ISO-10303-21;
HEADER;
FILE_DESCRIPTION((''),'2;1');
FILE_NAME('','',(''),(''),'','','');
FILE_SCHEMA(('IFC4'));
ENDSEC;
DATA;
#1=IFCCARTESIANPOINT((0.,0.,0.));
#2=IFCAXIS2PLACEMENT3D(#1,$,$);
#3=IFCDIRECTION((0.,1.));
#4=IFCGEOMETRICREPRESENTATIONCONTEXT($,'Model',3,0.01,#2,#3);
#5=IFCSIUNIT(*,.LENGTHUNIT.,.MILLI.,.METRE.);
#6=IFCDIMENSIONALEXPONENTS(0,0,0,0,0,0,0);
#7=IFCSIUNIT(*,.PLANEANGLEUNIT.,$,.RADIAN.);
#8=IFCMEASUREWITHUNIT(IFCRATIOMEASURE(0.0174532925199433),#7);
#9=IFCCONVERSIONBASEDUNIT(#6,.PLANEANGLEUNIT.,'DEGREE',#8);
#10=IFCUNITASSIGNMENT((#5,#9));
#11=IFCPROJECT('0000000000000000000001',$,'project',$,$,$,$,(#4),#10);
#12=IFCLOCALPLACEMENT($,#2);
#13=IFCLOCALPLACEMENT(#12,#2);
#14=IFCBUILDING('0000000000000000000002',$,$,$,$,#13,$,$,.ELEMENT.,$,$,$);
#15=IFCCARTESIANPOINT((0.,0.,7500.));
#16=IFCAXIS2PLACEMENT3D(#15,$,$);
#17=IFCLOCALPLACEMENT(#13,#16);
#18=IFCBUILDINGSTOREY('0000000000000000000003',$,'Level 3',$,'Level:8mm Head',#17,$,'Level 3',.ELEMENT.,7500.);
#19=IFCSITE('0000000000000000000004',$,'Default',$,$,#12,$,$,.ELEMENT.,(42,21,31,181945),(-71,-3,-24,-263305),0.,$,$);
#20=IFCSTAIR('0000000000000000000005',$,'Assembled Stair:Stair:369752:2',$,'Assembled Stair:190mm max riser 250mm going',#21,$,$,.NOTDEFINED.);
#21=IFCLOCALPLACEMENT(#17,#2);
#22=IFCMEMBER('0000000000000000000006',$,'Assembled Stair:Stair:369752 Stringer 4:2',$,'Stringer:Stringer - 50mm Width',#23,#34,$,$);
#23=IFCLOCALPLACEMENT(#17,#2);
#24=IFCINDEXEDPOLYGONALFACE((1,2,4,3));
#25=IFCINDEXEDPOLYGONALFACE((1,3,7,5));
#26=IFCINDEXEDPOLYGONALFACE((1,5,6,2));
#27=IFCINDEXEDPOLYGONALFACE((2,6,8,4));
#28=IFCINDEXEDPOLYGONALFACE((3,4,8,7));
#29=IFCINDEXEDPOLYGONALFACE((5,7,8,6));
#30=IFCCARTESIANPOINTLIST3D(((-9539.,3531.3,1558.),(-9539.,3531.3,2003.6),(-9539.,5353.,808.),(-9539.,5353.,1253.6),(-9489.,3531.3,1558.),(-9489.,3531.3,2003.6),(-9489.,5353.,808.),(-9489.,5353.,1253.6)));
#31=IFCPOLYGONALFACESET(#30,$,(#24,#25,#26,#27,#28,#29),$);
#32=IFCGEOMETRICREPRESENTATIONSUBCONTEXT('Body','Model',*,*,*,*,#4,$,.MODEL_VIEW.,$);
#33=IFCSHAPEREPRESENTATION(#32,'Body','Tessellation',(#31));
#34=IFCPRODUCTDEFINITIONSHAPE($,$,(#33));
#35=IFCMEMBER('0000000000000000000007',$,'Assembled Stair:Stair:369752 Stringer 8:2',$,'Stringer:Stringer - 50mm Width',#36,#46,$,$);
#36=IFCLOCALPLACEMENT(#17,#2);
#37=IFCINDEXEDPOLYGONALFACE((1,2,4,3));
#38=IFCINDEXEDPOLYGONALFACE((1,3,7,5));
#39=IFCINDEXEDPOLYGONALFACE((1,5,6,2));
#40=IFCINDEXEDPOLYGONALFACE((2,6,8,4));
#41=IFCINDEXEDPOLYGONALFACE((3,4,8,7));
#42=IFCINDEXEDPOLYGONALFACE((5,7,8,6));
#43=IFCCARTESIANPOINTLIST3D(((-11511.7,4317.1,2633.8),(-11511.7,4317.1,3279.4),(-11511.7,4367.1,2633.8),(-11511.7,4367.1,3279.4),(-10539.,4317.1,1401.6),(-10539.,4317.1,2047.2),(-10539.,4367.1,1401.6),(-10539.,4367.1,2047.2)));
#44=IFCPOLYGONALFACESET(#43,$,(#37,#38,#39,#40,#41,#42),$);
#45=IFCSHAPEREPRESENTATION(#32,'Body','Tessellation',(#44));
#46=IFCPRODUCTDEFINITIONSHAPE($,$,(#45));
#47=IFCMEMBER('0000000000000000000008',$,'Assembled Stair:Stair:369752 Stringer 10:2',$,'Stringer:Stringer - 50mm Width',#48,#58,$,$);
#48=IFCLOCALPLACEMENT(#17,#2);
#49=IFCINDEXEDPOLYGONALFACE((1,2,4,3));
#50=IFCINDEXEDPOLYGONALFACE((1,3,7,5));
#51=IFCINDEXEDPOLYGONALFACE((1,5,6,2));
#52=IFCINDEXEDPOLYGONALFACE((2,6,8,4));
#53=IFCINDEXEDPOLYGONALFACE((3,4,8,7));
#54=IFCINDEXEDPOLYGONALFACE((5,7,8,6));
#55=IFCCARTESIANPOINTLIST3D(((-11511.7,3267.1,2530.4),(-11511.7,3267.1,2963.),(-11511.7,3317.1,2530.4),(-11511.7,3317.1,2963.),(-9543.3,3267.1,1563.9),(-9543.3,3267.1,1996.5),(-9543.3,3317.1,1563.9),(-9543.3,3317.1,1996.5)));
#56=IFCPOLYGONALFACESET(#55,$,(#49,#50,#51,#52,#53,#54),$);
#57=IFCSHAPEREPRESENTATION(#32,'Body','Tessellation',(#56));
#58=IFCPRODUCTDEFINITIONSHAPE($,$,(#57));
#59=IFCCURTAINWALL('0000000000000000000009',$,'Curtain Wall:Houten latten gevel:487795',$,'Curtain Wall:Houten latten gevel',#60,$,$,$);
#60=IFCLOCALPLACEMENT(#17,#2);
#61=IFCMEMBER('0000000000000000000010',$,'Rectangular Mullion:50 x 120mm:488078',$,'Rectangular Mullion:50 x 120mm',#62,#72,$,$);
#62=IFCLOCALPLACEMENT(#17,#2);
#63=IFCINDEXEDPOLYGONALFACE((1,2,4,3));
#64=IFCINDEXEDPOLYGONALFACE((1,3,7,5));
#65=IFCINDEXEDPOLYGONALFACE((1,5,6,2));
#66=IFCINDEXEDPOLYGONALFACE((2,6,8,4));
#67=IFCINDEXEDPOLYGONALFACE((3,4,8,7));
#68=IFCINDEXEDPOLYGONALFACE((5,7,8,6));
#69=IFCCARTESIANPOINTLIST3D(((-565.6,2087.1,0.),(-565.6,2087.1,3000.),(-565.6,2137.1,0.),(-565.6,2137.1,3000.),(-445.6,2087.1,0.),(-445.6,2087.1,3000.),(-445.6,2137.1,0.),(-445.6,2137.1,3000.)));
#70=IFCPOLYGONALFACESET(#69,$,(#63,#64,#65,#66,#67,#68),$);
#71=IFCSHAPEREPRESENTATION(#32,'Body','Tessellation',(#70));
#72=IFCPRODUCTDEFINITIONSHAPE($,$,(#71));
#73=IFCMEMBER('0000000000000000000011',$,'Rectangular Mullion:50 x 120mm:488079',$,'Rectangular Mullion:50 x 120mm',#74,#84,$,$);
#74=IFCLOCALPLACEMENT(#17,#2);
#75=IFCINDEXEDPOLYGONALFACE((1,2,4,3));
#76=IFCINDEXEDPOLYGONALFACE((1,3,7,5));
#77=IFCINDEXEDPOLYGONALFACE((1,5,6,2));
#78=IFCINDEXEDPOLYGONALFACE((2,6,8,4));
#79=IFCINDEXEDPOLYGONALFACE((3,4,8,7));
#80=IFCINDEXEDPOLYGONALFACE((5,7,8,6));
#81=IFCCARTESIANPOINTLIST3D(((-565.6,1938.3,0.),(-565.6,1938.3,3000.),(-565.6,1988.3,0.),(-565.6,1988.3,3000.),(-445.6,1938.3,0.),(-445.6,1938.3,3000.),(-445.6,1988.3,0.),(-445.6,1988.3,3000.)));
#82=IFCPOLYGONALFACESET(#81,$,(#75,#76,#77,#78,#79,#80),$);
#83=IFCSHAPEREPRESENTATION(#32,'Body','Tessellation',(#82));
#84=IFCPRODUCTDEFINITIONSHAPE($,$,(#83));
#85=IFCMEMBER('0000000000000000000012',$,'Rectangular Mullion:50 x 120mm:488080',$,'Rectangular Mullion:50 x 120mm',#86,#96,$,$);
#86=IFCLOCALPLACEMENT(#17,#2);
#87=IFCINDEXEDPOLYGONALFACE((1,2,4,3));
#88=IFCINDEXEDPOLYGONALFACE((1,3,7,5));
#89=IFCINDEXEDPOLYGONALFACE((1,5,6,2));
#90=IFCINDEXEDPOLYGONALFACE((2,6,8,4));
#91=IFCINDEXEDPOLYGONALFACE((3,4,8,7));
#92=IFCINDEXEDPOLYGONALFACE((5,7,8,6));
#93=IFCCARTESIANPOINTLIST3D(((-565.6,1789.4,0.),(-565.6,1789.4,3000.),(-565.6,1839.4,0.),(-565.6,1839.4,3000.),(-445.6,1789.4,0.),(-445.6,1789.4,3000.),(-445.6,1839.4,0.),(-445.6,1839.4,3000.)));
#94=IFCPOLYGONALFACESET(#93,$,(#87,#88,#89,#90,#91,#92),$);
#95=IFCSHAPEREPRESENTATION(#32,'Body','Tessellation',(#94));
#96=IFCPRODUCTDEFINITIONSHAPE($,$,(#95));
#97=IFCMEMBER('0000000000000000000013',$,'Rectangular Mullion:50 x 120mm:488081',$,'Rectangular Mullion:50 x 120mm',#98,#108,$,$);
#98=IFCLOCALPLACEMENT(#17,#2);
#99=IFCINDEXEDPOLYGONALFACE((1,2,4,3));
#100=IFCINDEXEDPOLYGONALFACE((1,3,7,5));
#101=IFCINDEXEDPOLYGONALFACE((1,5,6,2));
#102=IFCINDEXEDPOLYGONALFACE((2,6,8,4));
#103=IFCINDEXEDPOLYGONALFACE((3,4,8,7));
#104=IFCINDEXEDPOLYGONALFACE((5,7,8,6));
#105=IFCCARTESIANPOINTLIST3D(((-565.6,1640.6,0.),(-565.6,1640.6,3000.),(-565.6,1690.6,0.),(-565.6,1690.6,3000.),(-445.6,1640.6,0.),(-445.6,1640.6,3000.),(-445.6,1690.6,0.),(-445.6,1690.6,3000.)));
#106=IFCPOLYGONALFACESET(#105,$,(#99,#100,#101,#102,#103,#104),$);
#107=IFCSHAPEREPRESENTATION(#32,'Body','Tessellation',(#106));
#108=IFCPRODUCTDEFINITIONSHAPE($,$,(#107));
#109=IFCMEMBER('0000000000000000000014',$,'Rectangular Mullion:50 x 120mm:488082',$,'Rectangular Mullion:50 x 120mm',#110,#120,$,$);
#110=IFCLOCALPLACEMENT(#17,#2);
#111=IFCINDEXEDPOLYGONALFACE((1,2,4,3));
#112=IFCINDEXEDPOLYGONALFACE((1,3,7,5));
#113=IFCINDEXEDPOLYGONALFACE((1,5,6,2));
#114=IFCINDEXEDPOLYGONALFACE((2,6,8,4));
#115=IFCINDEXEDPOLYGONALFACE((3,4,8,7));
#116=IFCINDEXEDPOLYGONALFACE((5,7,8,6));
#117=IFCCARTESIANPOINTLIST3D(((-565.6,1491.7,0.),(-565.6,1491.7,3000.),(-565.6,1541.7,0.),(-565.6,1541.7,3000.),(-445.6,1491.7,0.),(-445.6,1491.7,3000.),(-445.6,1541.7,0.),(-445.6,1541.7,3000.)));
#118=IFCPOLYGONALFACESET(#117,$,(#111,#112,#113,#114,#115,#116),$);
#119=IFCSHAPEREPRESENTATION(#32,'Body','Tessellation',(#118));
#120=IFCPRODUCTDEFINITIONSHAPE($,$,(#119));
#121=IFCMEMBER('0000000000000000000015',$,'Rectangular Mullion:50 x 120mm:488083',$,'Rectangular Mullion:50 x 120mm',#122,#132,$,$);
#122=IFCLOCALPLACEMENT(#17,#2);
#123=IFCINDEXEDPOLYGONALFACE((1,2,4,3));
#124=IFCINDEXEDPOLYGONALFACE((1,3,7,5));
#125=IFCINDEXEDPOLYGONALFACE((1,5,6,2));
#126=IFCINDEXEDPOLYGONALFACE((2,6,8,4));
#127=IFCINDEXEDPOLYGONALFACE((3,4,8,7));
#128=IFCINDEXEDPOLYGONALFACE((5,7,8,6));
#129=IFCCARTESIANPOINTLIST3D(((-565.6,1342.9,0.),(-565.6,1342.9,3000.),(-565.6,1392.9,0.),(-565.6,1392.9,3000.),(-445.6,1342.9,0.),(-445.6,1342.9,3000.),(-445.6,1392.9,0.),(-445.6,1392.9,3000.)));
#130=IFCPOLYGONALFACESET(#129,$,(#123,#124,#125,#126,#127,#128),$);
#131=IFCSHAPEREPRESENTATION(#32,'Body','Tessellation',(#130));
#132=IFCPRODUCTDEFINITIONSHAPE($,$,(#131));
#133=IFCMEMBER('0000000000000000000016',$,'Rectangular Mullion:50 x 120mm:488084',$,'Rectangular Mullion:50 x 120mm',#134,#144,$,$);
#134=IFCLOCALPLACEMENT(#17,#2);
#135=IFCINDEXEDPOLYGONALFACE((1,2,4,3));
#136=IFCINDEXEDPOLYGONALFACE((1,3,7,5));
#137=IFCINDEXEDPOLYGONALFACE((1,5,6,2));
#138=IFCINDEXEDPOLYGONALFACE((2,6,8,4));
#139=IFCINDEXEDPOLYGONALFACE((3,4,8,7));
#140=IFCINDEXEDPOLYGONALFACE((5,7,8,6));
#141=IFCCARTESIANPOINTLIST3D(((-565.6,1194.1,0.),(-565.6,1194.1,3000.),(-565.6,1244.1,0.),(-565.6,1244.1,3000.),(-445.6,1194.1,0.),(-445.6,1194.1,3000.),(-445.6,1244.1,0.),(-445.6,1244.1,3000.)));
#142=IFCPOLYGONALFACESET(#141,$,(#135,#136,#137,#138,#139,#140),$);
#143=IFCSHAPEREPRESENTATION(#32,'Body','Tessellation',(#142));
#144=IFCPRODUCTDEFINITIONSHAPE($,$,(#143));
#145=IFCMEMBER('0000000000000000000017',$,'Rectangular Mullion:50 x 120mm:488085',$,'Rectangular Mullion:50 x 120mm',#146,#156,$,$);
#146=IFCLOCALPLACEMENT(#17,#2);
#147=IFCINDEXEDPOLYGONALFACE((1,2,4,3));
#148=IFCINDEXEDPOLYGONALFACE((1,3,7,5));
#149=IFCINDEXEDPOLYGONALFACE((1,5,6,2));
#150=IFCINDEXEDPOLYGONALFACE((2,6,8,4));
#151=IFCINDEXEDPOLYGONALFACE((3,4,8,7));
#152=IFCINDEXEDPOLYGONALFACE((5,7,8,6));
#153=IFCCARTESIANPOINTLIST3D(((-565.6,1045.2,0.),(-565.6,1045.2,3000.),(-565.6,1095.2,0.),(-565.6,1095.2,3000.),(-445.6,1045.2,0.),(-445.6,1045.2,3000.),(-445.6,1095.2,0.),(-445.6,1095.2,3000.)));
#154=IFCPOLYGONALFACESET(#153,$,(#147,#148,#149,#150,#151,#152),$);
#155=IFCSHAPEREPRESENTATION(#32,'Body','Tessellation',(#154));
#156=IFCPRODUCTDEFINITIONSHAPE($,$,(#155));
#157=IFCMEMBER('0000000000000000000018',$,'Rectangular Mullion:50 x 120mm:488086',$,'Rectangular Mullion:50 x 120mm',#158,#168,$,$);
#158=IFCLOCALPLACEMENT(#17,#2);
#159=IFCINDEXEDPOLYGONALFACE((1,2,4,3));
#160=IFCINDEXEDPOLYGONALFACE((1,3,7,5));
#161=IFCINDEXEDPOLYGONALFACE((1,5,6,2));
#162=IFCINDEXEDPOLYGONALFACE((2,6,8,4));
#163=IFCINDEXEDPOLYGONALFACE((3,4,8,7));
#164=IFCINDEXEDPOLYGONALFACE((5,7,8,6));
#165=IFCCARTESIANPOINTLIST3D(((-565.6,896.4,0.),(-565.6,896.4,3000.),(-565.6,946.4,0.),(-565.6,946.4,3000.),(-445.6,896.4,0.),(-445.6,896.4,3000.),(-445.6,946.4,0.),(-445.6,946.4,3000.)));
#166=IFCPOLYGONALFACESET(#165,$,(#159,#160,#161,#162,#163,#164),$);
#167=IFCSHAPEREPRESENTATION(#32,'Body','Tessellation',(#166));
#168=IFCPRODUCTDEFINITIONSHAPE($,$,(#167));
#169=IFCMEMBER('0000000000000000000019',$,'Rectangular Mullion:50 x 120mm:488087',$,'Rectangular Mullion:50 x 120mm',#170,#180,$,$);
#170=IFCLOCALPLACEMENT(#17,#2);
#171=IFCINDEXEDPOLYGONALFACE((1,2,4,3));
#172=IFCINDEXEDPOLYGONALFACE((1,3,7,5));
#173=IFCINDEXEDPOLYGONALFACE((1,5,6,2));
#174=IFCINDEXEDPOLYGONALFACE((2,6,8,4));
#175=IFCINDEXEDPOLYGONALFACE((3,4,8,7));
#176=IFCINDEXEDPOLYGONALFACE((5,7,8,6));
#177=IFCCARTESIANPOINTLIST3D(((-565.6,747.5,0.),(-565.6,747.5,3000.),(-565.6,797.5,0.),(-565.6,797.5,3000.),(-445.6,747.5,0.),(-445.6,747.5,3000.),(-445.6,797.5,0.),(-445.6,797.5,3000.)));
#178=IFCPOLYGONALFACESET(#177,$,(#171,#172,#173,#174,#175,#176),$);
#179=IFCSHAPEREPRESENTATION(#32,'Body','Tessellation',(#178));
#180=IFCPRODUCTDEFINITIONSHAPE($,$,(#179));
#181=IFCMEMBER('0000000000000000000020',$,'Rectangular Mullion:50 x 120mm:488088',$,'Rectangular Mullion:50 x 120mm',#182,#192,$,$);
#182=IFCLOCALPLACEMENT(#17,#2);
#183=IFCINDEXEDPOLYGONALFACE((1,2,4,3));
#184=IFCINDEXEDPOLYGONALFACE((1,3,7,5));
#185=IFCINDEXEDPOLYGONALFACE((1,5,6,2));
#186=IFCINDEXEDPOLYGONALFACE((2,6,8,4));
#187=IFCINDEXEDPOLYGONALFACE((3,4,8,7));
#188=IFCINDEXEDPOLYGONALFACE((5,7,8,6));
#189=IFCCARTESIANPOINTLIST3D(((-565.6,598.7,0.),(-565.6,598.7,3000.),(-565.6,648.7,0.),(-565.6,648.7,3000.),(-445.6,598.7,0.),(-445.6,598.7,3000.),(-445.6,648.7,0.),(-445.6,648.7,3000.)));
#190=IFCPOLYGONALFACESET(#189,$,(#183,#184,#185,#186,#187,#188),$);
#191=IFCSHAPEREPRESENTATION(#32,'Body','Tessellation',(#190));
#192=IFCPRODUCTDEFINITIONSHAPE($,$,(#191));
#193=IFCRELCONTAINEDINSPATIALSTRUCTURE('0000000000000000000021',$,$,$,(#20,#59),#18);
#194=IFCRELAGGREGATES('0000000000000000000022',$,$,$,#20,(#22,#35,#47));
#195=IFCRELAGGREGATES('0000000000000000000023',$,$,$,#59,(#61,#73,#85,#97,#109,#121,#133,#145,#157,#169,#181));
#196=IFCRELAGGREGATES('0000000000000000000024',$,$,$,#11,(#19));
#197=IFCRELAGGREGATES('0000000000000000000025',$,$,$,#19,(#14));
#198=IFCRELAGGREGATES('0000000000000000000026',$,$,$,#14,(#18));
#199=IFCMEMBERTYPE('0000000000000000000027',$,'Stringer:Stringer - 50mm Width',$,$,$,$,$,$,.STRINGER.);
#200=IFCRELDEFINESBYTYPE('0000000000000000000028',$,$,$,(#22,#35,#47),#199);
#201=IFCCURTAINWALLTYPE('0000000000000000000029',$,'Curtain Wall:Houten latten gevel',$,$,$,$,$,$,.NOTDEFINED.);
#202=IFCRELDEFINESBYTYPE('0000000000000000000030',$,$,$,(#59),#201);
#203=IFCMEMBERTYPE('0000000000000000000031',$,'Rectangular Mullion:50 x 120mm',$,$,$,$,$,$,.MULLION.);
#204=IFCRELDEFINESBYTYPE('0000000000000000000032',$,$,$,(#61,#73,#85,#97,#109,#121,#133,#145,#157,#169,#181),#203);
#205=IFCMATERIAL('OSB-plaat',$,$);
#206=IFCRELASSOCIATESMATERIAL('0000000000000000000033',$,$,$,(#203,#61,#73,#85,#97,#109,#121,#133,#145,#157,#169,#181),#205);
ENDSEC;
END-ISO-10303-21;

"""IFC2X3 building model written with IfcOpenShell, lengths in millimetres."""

from ifc_helpers import new_model, entity, si_unit, converted_unit, direction, frame, origin, origin_2d_with_axis, place, context, subcontext, project, spatial, polyline, rectangle, outline, extrude, source, transform, mapped, material, type_object, type_shapes, element, aggregate, save


model = new_model("IFC2X3")

# Units and contexts
model_context = context("Model", 3, precision=0.01, world=origin(), true_north=direction((0.0, 1.0)))
body_context = subcontext(model_context, "Body", "Model", "MODEL_VIEW")
ifc_project = project(units=[si_unit("LENGTHUNIT", "METRE", prefix="MILLI"), converted_unit("PLANEANGLEUNIT", "DEGREE", entity("IfcRatioMeasure", 0.0174532925199433), si_unit("PLANEANGLEUNIT", "RADIAN"), dimensions=[0, 0, 0, 0, 0, 0, 0])], contexts=[model_context])

# Site, building, storey
site_placement = place(None, frame((0.0, 0.0, 0.0)))
site = spatial("IfcSite", under=ifc_project, at=site_placement, Name="Default", CompositionType="ELEMENT", RefLatitude=(42, 21, 31, 181945), RefLongitude=(-71, -3, -24, -263305), RefElevation=0.0)
building_placement = place(site_placement, origin())
building = spatial("IfcBuilding", under=site, at=building_placement, CompositionType="ELEMENT")
storey_placement = place(building_placement, frame((0.0, 0.0, 7500.0)))
storey = spatial("IfcBuildingStorey", under=building, at=storey_placement, Name="Level 3", ObjectType="Level:8mm Head", LongName="Level 3", CompositionType="ELEMENT", Elevation=7500.0)

# Stair, members
stair_placement = place(storey_placement, origin())
stair = element("IfcStair", 1, at=stair_placement, inside=storey, Name="Assembled Stair:Stair:369752:2", ObjectType="Assembled Stair:190mm max riser 250mm going", ShapeType="NOTDEFINED")
member_type_1 = type_object("IfcMemberType", Name="Stringer:Stringer - 50mm Width", PredefinedType="STRINGER")
member_1_placement = place(stair_placement, origin())
member_1 = element("IfcMember", 2, at=member_1_placement, type_object=member_type_1, Name="Assembled Stair:Stair:369752 Stringer 4:2", ObjectType="Stringer:Stringer - 50mm Width", context=body_context, shape_type="SweptSolid", body=[
    extrude(outline(polyline([(-900.2, -206.0), (1069.9, -206.0), (900.2, 206.0), (-1069.9, 206.0), (-900.2, -206.0)])), frame((-9539.0, 4442.1, 1405.8), z_axis=(1.0, 0.0, 0.0), x_axis=(0.0, -0.924702, 0.380692)), (0.0, 0.0, 1.0), 50.0),
])
member_2_placement = place(stair_placement, origin())
member_2 = element("IfcMember", 3, at=member_2_placement, type_object=member_type_1, Name="Assembled Stair:Stair:369752 Stringer 8:2", ObjectType="Stringer:Stringer - 50mm Width", context=body_context, shape_type="SweptSolid", body=[
    extrude(outline(polyline([(-1038.3, -200.0), (531.5, -200.0), (1038.3, 200.0), (-531.5, 200.0), (-1038.3, -200.0)])), frame((-11025.3, 4317.1, 2340.5), z_axis=(0.0, 1.0, 0.0), x_axis=(-0.619602, 0.0, 0.784916)), (0.0, 0.0, 1.0), 50.0),
])
member_3_placement = place(stair_placement, origin())
member_3 = element("IfcMember", 4, at=member_3_placement, type_object=member_type_1, Name="Assembled Stair:Stair:369752 Stringer 10:2", ObjectType="Stringer:Stringer - 50mm Width", context=body_context, shape_type="SweptSolid", body=[
    extrude(outline(polyline([(-1191.8, -194.1), (1001.1, -194.1), (1191.8, 194.1), (-1001.1, 194.1), (-1191.8, -194.1)])), frame((-10527.5, 3267.1, 2263.4), z_axis=(0.0, 1.0, 0.0), x_axis=(-0.897628, 0.0, 0.440753)), (0.0, 0.0, 1.0), 50.0),
])
aggregate(stair, [member_1, member_2, member_3])

# Curtain wall, members
curtain_wall_type = type_object("IfcCurtainWallType", Name="Curtain Wall:Houten latten gevel", PredefinedType="NOTDEFINED")
curtain_wall_placement = place(storey_placement, frame((0.0, 0.0, -7500.0)))
curtain_wall = element("IfcCurtainWall", 5, at=curtain_wall_placement, inside=storey, type_object=curtain_wall_type, Name="Curtain Wall:Houten latten gevel:487795", ObjectType="Curtain Wall:Houten latten gevel")
ifc_material = material(Name="OSB-plaat")
member_type_2 = type_object("IfcMemberType", Name="Rectangular Mullion:50 x 120mm", PredefinedType="MULLION", material=ifc_material)
shared_shape = source(origin(), body_context, "Body", "SweptSolid", [
    extrude(rectangle(XDim=120.0, YDim=50.0, at=origin_2d_with_axis()), frame((0.0, 0.0, -3000.0), z_axis=(0.0, 0.0, 1.0), x_axis=(0.0, -1.0, 0.0)), (0.0, 0.0, 1.0), 3000.0),
])
type_shapes(member_type_2, [shared_shape])
member_4_placement = place(storey_placement, frame((-505.6, 2112.1, 0.0), z_axis=(0.0, 0.0, -1.0), x_axis=(0.0, -1.0, 0.0)))
member_4 = element("IfcMember", 6, at=member_4_placement, type_object=member_type_2, material=ifc_material, Name="Rectangular Mullion:50 x 120mm:488078", ObjectType="Rectangular Mullion:50 x 120mm", context=body_context, shape_type="MappedRepresentation", body=[
    mapped(shared_shape, transform((0.0, 0.0, 0.0), scale=1.0)),
])
member_5_placement = place(storey_placement, frame((-505.6, 1963.3, 0.0), z_axis=(0.0, 0.0, -1.0), x_axis=(0.0, -1.0, 0.0)))
member_5 = element("IfcMember", 7, at=member_5_placement, type_object=member_type_2, material=ifc_material, Name="Rectangular Mullion:50 x 120mm:488079", ObjectType="Rectangular Mullion:50 x 120mm", context=body_context, shape_type="MappedRepresentation", body=[
    mapped(shared_shape, transform((0.0, 0.0, 0.0), scale=1.0)),
])
member_6_placement = place(storey_placement, frame((-505.6, 1814.4, 0.0), z_axis=(0.0, 0.0, -1.0), x_axis=(0.0, -1.0, 0.0)))
member_6 = element("IfcMember", 8, at=member_6_placement, type_object=member_type_2, material=ifc_material, Name="Rectangular Mullion:50 x 120mm:488080", ObjectType="Rectangular Mullion:50 x 120mm", context=body_context, shape_type="MappedRepresentation", body=[
    mapped(shared_shape, transform((0.0, 0.0, 0.0), scale=1.0)),
])
member_7_placement = place(storey_placement, frame((-505.6, 1665.6, 0.0), z_axis=(0.0, 0.0, -1.0), x_axis=(0.0, -1.0, 0.0)))
member_7 = element("IfcMember", 9, at=member_7_placement, type_object=member_type_2, material=ifc_material, Name="Rectangular Mullion:50 x 120mm:488081", ObjectType="Rectangular Mullion:50 x 120mm", context=body_context, shape_type="MappedRepresentation", body=[
    mapped(shared_shape, transform((0.0, 0.0, 0.0), scale=1.0)),
])
member_8_placement = place(storey_placement, frame((-505.6, 1516.7, 0.0), z_axis=(0.0, 0.0, -1.0), x_axis=(0.0, -1.0, 0.0)))
member_8 = element("IfcMember", 10, at=member_8_placement, type_object=member_type_2, material=ifc_material, Name="Rectangular Mullion:50 x 120mm:488082", ObjectType="Rectangular Mullion:50 x 120mm", context=body_context, shape_type="MappedRepresentation", body=[
    mapped(shared_shape, transform((0.0, 0.0, 0.0), scale=1.0)),
])
member_9_placement = place(storey_placement, frame((-505.6, 1367.9, 0.0), z_axis=(0.0, 0.0, -1.0), x_axis=(0.0, -1.0, 0.0)))
member_9 = element("IfcMember", 11, at=member_9_placement, type_object=member_type_2, material=ifc_material, Name="Rectangular Mullion:50 x 120mm:488083", ObjectType="Rectangular Mullion:50 x 120mm", context=body_context, shape_type="MappedRepresentation", body=[
    mapped(shared_shape, transform((0.0, 0.0, 0.0), scale=1.0)),
])
member_10_placement = place(storey_placement, frame((-505.6, 1219.1, 0.0), z_axis=(0.0, 0.0, -1.0), x_axis=(0.0, -1.0, 0.0)))
member_10 = element("IfcMember", 12, at=member_10_placement, type_object=member_type_2, material=ifc_material, Name="Rectangular Mullion:50 x 120mm:488084", ObjectType="Rectangular Mullion:50 x 120mm", context=body_context, shape_type="MappedRepresentation", body=[
    mapped(shared_shape, transform((0.0, 0.0, 0.0), scale=1.0)),
])
member_11_placement = place(storey_placement, frame((-505.6, 1070.2, 0.0), z_axis=(0.0, 0.0, -1.0), x_axis=(0.0, -1.0, 0.0)))
member_11 = element("IfcMember", 13, at=member_11_placement, type_object=member_type_2, material=ifc_material, Name="Rectangular Mullion:50 x 120mm:488085", ObjectType="Rectangular Mullion:50 x 120mm", context=body_context, shape_type="MappedRepresentation", body=[
    mapped(shared_shape, transform((0.0, 0.0, 0.0), scale=1.0)),
])
member_12_placement = place(storey_placement, frame((-505.6, 921.4, 0.0), z_axis=(0.0, 0.0, -1.0), x_axis=(0.0, -1.0, 0.0)))
member_12 = element("IfcMember", 14, at=member_12_placement, type_object=member_type_2, material=ifc_material, Name="Rectangular Mullion:50 x 120mm:488086", ObjectType="Rectangular Mullion:50 x 120mm", context=body_context, shape_type="MappedRepresentation", body=[
    mapped(shared_shape, transform((0.0, 0.0, 0.0), scale=1.0)),
])
member_13_placement = place(storey_placement, frame((-505.6, 772.5, 0.0), z_axis=(0.0, 0.0, -1.0), x_axis=(0.0, -1.0, 0.0)))
member_13 = element("IfcMember", 15, at=member_13_placement, type_object=member_type_2, material=ifc_material, Name="Rectangular Mullion:50 x 120mm:488087", ObjectType="Rectangular Mullion:50 x 120mm", context=body_context, shape_type="MappedRepresentation", body=[
    mapped(shared_shape, transform((0.0, 0.0, 0.0), scale=1.0)),
])
member_14_placement = place(storey_placement, frame((-505.6, 623.7, 0.0), z_axis=(0.0, 0.0, -1.0), x_axis=(0.0, -1.0, 0.0)))
member_14 = element("IfcMember", 16, at=member_14_placement, type_object=member_type_2, material=ifc_material, Name="Rectangular Mullion:50 x 120mm:488088", ObjectType="Rectangular Mullion:50 x 120mm", context=body_context, shape_type="MappedRepresentation", body=[
    mapped(shared_shape, transform((0.0, 0.0, 0.0), scale=1.0)),
])
aggregate(curtain_wall, [member_4, member_5, member_6, member_7, member_8, member_9, member_10, member_11, member_12, member_13, member_14])

save(model, "model.ifc")
